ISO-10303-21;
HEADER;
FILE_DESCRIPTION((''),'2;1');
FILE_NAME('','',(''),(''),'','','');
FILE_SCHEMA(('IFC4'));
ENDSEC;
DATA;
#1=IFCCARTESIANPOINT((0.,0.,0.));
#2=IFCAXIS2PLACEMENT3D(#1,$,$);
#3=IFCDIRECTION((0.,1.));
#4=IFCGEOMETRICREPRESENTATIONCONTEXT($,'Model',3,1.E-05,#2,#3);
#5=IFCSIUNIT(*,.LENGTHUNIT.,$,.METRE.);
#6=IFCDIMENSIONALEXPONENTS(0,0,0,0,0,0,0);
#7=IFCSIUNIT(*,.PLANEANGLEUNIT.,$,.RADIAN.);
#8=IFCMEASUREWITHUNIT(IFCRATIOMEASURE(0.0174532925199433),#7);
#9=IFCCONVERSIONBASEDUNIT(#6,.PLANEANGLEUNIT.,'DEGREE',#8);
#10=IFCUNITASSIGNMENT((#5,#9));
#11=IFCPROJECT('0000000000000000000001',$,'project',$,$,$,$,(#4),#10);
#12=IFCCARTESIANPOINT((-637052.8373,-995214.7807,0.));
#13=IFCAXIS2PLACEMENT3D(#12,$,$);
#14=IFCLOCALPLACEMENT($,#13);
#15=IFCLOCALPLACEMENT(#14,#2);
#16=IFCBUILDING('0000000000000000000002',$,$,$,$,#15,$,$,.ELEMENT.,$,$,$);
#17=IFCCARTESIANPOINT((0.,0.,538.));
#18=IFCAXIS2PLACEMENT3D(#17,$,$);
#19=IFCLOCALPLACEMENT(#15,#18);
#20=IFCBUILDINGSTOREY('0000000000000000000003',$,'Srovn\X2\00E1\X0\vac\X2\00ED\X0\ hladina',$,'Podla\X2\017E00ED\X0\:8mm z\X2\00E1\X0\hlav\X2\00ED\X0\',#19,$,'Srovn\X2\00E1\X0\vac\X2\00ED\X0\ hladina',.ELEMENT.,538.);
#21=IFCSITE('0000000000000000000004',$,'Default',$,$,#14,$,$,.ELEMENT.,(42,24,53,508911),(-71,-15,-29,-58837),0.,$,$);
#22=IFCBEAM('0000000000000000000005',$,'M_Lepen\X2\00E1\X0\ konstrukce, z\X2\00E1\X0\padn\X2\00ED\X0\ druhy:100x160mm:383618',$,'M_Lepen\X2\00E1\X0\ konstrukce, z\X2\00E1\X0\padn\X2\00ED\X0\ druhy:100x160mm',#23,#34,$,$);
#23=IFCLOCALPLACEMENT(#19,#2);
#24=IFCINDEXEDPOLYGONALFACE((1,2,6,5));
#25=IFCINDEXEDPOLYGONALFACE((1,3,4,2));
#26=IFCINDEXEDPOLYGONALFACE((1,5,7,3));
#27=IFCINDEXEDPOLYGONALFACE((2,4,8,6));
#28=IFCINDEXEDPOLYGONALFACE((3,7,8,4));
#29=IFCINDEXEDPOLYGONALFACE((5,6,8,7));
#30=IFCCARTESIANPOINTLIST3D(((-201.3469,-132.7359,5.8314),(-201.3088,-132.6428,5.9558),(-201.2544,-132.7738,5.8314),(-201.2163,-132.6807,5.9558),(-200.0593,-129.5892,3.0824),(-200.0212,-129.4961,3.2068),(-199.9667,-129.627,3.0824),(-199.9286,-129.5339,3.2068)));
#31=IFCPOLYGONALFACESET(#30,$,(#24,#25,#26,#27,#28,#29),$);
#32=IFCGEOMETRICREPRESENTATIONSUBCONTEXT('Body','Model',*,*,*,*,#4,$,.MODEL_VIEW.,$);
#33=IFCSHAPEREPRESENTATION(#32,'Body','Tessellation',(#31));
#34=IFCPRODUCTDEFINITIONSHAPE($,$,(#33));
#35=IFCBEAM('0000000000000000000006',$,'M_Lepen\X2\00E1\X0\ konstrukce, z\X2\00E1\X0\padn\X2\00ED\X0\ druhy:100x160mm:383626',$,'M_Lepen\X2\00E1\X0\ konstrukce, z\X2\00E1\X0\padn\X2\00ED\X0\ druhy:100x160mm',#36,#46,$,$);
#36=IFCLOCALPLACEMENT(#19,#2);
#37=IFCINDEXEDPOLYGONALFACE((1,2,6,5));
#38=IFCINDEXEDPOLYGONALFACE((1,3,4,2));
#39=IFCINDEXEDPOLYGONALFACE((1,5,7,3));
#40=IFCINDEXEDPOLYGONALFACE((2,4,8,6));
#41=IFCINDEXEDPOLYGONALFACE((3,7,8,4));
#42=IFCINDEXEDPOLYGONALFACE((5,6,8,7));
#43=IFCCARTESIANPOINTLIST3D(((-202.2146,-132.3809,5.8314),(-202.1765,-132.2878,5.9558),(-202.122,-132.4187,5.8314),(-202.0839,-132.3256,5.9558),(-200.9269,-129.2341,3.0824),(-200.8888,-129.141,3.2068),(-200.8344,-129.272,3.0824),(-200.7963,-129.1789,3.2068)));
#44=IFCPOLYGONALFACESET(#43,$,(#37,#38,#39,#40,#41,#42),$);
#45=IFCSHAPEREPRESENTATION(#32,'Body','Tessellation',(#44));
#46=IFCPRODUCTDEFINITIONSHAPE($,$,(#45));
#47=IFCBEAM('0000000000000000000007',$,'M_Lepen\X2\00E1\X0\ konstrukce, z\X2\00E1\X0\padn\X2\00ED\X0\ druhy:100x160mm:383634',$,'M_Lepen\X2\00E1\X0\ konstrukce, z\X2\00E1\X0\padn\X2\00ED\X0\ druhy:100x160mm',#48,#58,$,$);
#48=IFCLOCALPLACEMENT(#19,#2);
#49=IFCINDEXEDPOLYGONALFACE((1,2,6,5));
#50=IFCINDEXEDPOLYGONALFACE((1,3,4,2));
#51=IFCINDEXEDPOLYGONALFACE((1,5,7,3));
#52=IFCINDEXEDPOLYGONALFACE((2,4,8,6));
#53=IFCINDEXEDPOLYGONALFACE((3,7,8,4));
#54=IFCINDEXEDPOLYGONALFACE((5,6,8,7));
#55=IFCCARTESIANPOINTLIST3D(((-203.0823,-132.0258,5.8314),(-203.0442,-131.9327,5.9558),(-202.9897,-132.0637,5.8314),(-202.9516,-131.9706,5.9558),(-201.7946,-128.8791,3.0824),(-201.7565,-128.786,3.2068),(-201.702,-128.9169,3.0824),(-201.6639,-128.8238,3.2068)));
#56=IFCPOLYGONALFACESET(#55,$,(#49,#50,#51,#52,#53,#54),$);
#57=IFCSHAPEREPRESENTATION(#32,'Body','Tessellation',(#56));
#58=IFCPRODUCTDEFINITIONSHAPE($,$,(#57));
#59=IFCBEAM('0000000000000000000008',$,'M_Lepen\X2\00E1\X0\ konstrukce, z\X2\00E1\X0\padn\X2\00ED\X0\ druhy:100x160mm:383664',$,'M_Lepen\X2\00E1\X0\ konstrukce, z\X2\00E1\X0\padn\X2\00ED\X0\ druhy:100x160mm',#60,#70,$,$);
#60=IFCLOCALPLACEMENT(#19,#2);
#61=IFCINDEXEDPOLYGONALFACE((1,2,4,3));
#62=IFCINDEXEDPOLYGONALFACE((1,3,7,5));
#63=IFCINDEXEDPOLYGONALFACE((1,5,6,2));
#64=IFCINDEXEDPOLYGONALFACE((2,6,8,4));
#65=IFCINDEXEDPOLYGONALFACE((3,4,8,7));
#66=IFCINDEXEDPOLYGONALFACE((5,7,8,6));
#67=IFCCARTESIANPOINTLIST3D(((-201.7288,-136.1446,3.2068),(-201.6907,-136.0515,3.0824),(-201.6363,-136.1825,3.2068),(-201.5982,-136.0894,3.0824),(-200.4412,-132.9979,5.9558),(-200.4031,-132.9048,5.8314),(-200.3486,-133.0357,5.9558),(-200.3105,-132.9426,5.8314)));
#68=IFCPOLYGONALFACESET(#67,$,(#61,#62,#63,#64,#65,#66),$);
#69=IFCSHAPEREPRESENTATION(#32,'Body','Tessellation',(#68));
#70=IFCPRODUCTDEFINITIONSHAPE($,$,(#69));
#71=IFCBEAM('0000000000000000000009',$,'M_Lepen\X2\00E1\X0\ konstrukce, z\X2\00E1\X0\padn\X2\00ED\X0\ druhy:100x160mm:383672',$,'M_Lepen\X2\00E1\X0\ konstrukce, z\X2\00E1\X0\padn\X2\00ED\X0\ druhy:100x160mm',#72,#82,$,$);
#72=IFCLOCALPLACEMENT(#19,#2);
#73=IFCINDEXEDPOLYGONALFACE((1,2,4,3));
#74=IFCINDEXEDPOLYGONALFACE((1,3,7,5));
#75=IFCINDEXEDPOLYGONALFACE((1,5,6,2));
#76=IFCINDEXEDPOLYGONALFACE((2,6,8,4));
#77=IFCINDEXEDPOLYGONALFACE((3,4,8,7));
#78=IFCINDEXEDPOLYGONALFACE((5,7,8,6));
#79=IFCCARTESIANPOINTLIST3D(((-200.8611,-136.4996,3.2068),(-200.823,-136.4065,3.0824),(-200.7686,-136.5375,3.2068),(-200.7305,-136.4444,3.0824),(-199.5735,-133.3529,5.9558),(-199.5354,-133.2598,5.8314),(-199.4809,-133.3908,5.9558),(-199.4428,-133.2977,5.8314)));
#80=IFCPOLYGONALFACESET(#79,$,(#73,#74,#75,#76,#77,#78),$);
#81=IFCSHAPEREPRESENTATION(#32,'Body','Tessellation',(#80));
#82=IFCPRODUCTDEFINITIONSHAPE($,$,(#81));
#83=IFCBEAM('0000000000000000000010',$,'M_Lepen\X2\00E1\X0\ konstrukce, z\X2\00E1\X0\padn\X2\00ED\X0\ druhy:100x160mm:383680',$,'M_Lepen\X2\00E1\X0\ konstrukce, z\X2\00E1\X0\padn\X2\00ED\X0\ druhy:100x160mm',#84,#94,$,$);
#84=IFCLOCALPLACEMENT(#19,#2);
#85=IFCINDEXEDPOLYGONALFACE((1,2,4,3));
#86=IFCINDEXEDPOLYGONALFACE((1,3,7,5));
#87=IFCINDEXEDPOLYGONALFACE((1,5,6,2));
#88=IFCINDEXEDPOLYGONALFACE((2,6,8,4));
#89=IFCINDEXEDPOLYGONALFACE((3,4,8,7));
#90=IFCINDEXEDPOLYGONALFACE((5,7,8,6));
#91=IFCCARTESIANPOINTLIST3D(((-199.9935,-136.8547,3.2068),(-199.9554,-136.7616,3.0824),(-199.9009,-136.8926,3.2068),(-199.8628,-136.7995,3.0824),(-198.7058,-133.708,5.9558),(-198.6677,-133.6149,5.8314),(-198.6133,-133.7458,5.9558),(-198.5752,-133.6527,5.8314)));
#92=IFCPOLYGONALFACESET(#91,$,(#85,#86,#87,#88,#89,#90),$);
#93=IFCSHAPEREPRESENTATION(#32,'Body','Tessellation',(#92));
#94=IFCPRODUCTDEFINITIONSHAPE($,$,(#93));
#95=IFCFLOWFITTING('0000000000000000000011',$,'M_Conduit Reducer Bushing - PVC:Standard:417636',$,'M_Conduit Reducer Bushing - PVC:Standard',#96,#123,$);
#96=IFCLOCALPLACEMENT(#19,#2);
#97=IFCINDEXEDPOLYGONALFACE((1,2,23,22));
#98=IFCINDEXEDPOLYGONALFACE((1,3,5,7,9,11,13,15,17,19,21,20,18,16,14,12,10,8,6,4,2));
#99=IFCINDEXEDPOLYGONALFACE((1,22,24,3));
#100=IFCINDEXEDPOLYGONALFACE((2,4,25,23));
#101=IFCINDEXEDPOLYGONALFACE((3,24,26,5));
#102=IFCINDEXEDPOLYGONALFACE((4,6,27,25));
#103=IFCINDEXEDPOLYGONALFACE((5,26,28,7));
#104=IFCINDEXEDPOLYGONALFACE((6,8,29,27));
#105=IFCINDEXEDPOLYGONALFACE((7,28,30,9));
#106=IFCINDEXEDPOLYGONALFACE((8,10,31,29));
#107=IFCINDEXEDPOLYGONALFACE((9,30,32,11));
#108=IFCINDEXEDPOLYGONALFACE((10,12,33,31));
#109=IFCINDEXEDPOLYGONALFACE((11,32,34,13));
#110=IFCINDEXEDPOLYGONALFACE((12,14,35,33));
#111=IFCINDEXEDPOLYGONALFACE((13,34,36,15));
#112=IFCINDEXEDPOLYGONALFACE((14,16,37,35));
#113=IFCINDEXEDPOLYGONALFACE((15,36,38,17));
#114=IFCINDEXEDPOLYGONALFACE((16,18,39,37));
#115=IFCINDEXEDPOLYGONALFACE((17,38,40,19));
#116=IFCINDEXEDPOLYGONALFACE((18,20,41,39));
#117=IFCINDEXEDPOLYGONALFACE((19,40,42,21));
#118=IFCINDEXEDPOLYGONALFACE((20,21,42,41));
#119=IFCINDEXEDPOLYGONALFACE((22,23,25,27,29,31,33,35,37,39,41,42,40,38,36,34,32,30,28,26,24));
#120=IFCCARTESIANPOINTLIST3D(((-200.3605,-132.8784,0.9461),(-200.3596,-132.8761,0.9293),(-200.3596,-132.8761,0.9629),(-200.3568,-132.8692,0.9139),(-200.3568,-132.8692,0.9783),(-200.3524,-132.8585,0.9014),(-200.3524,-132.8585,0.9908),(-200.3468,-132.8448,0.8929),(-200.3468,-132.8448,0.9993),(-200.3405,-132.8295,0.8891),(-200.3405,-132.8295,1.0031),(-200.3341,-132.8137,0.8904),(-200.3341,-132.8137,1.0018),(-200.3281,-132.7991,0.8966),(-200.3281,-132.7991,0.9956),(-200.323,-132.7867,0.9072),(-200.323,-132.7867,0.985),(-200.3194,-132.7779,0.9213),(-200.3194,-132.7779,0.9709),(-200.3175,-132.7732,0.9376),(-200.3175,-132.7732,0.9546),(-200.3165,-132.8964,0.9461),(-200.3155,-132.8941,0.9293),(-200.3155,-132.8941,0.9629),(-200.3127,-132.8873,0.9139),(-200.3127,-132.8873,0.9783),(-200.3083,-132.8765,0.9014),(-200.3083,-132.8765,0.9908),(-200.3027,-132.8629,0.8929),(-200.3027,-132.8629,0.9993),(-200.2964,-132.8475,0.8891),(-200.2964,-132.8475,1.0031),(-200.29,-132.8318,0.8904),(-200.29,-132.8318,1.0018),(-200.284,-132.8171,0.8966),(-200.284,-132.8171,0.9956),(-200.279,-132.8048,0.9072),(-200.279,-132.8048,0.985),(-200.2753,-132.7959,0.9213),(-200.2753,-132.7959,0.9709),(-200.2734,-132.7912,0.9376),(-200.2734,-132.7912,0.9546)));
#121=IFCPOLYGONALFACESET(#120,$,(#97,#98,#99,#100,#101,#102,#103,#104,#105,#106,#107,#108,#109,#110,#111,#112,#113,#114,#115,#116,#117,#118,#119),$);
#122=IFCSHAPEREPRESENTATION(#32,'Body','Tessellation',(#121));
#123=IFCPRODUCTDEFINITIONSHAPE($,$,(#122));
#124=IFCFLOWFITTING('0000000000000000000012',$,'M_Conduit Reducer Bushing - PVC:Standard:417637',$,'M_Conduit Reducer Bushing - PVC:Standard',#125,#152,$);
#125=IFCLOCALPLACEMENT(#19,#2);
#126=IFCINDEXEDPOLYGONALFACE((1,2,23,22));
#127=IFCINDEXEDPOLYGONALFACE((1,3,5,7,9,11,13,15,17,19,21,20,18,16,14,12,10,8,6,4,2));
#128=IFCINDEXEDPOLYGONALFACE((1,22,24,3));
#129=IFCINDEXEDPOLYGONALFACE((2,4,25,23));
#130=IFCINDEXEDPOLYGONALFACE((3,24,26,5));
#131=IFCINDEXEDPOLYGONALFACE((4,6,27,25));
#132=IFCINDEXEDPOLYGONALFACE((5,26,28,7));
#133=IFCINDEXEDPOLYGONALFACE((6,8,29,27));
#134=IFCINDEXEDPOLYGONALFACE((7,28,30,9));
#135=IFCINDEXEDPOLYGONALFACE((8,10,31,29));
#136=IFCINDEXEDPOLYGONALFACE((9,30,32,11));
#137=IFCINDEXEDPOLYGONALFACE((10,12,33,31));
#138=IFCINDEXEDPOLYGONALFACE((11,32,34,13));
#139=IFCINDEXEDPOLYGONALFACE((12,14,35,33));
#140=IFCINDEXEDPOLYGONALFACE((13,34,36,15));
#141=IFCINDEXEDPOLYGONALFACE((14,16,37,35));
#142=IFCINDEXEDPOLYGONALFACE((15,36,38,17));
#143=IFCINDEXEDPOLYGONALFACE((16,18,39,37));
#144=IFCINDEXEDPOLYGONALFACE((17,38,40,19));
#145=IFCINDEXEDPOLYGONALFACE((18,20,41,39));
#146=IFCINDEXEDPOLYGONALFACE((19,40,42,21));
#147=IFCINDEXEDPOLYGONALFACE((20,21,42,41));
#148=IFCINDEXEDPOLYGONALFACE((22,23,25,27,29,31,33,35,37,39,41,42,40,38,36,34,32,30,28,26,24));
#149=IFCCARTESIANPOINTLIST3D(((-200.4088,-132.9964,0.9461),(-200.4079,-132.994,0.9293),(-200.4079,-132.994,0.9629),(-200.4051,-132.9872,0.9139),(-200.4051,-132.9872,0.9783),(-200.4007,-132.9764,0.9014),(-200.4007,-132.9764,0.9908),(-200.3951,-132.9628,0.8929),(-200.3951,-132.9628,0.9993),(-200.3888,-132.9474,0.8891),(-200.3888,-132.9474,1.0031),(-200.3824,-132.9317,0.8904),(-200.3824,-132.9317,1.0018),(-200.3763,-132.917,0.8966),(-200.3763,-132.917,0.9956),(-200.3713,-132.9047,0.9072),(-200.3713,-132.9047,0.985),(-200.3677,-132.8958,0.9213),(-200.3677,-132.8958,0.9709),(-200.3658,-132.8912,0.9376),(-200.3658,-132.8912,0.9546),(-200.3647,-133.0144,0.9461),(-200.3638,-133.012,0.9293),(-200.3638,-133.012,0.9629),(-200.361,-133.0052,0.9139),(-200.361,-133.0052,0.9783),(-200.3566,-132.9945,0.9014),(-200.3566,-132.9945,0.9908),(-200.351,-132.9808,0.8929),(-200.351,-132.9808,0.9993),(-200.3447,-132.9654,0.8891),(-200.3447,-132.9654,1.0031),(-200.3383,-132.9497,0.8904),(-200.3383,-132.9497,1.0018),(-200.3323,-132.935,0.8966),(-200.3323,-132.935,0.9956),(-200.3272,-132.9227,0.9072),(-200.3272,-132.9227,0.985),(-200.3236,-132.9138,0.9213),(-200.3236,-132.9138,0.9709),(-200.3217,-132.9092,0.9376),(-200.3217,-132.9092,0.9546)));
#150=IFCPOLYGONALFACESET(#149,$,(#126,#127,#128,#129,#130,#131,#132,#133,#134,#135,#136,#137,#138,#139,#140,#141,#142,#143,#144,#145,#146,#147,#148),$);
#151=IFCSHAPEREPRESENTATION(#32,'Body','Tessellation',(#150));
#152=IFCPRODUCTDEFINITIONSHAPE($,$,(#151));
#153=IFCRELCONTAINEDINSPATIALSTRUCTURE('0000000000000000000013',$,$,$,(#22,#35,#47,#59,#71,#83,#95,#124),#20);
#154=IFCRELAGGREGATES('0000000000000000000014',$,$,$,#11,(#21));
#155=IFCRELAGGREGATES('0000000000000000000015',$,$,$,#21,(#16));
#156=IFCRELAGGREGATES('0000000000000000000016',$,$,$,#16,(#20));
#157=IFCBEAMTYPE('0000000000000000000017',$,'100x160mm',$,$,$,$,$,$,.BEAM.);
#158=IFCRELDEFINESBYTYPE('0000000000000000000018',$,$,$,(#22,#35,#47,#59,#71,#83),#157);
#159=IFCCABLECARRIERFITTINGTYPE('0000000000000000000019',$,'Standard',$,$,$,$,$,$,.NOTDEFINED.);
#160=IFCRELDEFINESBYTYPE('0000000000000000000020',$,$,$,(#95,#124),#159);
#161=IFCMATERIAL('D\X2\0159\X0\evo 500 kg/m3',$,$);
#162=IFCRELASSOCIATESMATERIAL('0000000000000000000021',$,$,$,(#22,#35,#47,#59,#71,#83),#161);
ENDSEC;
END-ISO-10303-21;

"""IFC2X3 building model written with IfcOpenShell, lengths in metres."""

from ifc_helpers import new_model, entity, si_unit, converted_unit, direction, frame, frame_2d, origin, place, context, subcontext, project, spatial, rectangle, circle, extrude, source, transform, mapped, material, type_object, type_shapes, element, save


model = new_model("IFC2X3")

# Units and contexts
model_context = context("Model", 3, precision=1e-05, world=origin(), true_north=direction((0.0, 1.0)))
body_context = subcontext(model_context, "Body", "Model", "MODEL_VIEW")
ifc_project = project(units=[si_unit("LENGTHUNIT", "METRE"), converted_unit("PLANEANGLEUNIT", "DEGREE", entity("IfcRatioMeasure", 0.0174532925199433), si_unit("PLANEANGLEUNIT", "RADIAN"), dimensions=[0, 0, 0, 0, 0, 0, 0])], contexts=[model_context])

# Site, building, storey
site_placement = place(None, frame((-637052.8373, -995214.7807, 0.0)))
site = spatial("IfcSite", under=ifc_project, at=site_placement, Name="Default", CompositionType="ELEMENT", RefLatitude=(42, 24, 53, 508911), RefLongitude=(-71, -15, -29, -58837), RefElevation=0.0)
building_placement = place(site_placement, origin())
building = spatial("IfcBuilding", under=site, at=building_placement, CompositionType="ELEMENT")
storey_placement = place(building_placement, frame((0.0, 0.0, 538.0)))
storey = spatial("IfcBuildingStorey", under=building, at=storey_placement, Name="Srovnávací hladina", ObjectType="Podlaží:8mm záhlaví", LongName="Srovnávací hladina", CompositionType="ELEMENT", Elevation=538.0)

# Beams
ifc_material_1 = material(Name="Dřevo 500 kg/m3")
beam_type_1 = type_object("IfcBeamType", Name="100x160mm", PredefinedType="BEAM")
beam_1_placement = place(storey_placement, frame((-199.9749, -129.515, 3.2068), z_axis=(0.238114, 0.581897, 0.777623), x_axis=(-0.294503, -0.719698, 0.628731)))
element("IfcBeam", 1, at=beam_1_placement, inside=storey, type_object=beam_type_1, material=ifc_material_1, Name="M_Lepená konstrukce, západní druhy:100x160mm:383618", ObjectType="M_Lepená konstrukce, západní druhy:100x160mm", context=body_context, shape_type="SweptSolid", body=[
    extrude(rectangle(XDim=0.16, YDim=0.1, at=frame_2d((0.0, 0.0), x_axis=(1.0, 0.0))), frame((0.0, 0.0, -0.08), z_axis=(1.0, 0.0, 0.0), x_axis=(0.0, 0.0, -1.0)), (0.0, 0.0, 1.0), 4.3723),
])
beam_2_placement = place(storey_placement, frame((-200.8426, -129.16, 3.2068), z_axis=(0.238114, 0.581897, 0.777623), x_axis=(-0.294503, -0.719698, 0.628731)))
element("IfcBeam", 2, at=beam_2_placement, inside=storey, type_object=beam_type_1, material=ifc_material_1, Name="M_Lepená konstrukce, západní druhy:100x160mm:383626", ObjectType="M_Lepená konstrukce, západní druhy:100x160mm", context=body_context, shape_type="SweptSolid", body=[
    extrude(rectangle(XDim=0.16, YDim=0.1, at=frame_2d((0.0, 0.0), x_axis=(1.0, 0.0))), frame((0.0, 0.0, -0.08), z_axis=(1.0, 0.0, 0.0), x_axis=(0.0, 0.0, -1.0)), (0.0, 0.0, 1.0), 4.3723),
])
beam_3_placement = place(storey_placement, frame((-201.7102, -128.8049, 3.2068), z_axis=(0.238114, 0.581897, 0.777623), x_axis=(-0.294503, -0.719698, 0.628731)))
element("IfcBeam", 3, at=beam_3_placement, inside=storey, type_object=beam_type_1, material=ifc_material_1, Name="M_Lepená konstrukce, západní druhy:100x160mm:383634", ObjectType="M_Lepená konstrukce, západní druhy:100x160mm", context=body_context, shape_type="SweptSolid", body=[
    extrude(rectangle(XDim=0.16, YDim=0.1, at=frame_2d((0.0, 0.0), x_axis=(1.0, 0.0))), frame((0.0, 0.0, -0.08), z_axis=(1.0, 0.0, 0.0), x_axis=(0.0, 0.0, -1.0)), (0.0, 0.0, 1.0), 4.3723),
])
beam_4_placement = place(storey_placement, frame((-201.6825, -136.1635, 3.2068), z_axis=(-0.238114, -0.581897, 0.777623), x_axis=(0.294503, 0.719698, 0.628731)))
element("IfcBeam", 4, at=beam_4_placement, inside=storey, type_object=beam_type_1, material=ifc_material_1, Name="M_Lepená konstrukce, západní druhy:100x160mm:383664", ObjectType="M_Lepená konstrukce, západní druhy:100x160mm", context=body_context, shape_type="SweptSolid", body=[
    extrude(rectangle(XDim=0.16, YDim=0.1, at=frame_2d((0.0, 0.0), x_axis=(1.0, 0.0))), frame((0.0, 0.0, -0.08), z_axis=(1.0, 0.0, 0.0), x_axis=(0.0, 0.0, -1.0)), (0.0, 0.0, 1.0), 4.3723),
])
beam_5_placement = place(storey_placement, frame((-200.8149, -136.5186, 3.2068), z_axis=(-0.238114, -0.581897, 0.777623), x_axis=(0.294503, 0.719698, 0.628731)))
element("IfcBeam", 5, at=beam_5_placement, inside=storey, type_object=beam_type_1, material=ifc_material_1, Name="M_Lepená konstrukce, západní druhy:100x160mm:383672", ObjectType="M_Lepená konstrukce, západní druhy:100x160mm", context=body_context, shape_type="SweptSolid", body=[
    extrude(rectangle(XDim=0.16, YDim=0.1, at=frame_2d((0.0, 0.0), x_axis=(1.0, 0.0))), frame((0.0, 0.0, -0.08), z_axis=(1.0, 0.0, 0.0), x_axis=(0.0, 0.0, -1.0)), (0.0, 0.0, 1.0), 4.3723),
])
beam_6_placement = place(storey_placement, frame((-199.9472, -136.8736, 3.2068), z_axis=(-0.238114, -0.581897, 0.777623), x_axis=(0.294503, 0.719698, 0.628731)))
element("IfcBeam", 6, at=beam_6_placement, inside=storey, type_object=beam_type_1, material=ifc_material_1, Name="M_Lepená konstrukce, západní druhy:100x160mm:383680", ObjectType="M_Lepená konstrukce, západní druhy:100x160mm", context=body_context, shape_type="SweptSolid", body=[
    extrude(rectangle(XDim=0.16, YDim=0.1, at=frame_2d((0.0, 0.0), x_axis=(1.0, 0.0))), frame((0.0, 0.0, -0.08), z_axis=(1.0, 0.0, 0.0), x_axis=(0.0, 0.0, -1.0)), (0.0, 0.0, 1.0), 4.3723),
])

# Flow fittings
cable_carrier_fitting_type = type_object("IfcCableCarrierFittingType", Name="Standard", PredefinedType="NOTDEFINED")
shared_shape = source(origin(), body_context, "Body", "SweptSolid", [
    extrude(circle(Radius=0.0571, at=frame_2d((0.0, 0.0), x_axis=(1.0, 0.0))), frame((0.0, 0.0, 0.0), z_axis=(1.0, 0.0, 0.0), x_axis=(0.0, 1.0, 0.0)), (0.0, 0.0, 1.0), 0.0476),
])
type_shapes(cable_carrier_fitting_type, [shared_shape])
for number, where, z_axis, x_axis, name in (
    (7, (-200.2948, -132.8435, 0.9461), (0.0, 0.0, 1.0), (-0.92551, 0.378722, 0.0), "M_Conduit Reducer Bushing - PVC:Standard:417636"),
    (8, (-200.3431, -132.9615, 0.9461), (0.0, 0.0, 1.0), (-0.92551, 0.378722, 0.0), "M_Conduit Reducer Bushing - PVC:Standard:417637"),
):
    element("IfcFlowFitting", number, at=place(storey_placement, frame(where, z_axis=z_axis, x_axis=x_axis)), inside=storey, type_object=cable_carrier_fitting_type, Name=name, ObjectType="M_Conduit Reducer Bushing - PVC:Standard", context=body_context, shape_type="MappedRepresentation", body=[
        mapped(shared_shape, transform((0.0, 0.0, 0.0), scale=1.0)),
    ])

save(model, "model.ifc")
